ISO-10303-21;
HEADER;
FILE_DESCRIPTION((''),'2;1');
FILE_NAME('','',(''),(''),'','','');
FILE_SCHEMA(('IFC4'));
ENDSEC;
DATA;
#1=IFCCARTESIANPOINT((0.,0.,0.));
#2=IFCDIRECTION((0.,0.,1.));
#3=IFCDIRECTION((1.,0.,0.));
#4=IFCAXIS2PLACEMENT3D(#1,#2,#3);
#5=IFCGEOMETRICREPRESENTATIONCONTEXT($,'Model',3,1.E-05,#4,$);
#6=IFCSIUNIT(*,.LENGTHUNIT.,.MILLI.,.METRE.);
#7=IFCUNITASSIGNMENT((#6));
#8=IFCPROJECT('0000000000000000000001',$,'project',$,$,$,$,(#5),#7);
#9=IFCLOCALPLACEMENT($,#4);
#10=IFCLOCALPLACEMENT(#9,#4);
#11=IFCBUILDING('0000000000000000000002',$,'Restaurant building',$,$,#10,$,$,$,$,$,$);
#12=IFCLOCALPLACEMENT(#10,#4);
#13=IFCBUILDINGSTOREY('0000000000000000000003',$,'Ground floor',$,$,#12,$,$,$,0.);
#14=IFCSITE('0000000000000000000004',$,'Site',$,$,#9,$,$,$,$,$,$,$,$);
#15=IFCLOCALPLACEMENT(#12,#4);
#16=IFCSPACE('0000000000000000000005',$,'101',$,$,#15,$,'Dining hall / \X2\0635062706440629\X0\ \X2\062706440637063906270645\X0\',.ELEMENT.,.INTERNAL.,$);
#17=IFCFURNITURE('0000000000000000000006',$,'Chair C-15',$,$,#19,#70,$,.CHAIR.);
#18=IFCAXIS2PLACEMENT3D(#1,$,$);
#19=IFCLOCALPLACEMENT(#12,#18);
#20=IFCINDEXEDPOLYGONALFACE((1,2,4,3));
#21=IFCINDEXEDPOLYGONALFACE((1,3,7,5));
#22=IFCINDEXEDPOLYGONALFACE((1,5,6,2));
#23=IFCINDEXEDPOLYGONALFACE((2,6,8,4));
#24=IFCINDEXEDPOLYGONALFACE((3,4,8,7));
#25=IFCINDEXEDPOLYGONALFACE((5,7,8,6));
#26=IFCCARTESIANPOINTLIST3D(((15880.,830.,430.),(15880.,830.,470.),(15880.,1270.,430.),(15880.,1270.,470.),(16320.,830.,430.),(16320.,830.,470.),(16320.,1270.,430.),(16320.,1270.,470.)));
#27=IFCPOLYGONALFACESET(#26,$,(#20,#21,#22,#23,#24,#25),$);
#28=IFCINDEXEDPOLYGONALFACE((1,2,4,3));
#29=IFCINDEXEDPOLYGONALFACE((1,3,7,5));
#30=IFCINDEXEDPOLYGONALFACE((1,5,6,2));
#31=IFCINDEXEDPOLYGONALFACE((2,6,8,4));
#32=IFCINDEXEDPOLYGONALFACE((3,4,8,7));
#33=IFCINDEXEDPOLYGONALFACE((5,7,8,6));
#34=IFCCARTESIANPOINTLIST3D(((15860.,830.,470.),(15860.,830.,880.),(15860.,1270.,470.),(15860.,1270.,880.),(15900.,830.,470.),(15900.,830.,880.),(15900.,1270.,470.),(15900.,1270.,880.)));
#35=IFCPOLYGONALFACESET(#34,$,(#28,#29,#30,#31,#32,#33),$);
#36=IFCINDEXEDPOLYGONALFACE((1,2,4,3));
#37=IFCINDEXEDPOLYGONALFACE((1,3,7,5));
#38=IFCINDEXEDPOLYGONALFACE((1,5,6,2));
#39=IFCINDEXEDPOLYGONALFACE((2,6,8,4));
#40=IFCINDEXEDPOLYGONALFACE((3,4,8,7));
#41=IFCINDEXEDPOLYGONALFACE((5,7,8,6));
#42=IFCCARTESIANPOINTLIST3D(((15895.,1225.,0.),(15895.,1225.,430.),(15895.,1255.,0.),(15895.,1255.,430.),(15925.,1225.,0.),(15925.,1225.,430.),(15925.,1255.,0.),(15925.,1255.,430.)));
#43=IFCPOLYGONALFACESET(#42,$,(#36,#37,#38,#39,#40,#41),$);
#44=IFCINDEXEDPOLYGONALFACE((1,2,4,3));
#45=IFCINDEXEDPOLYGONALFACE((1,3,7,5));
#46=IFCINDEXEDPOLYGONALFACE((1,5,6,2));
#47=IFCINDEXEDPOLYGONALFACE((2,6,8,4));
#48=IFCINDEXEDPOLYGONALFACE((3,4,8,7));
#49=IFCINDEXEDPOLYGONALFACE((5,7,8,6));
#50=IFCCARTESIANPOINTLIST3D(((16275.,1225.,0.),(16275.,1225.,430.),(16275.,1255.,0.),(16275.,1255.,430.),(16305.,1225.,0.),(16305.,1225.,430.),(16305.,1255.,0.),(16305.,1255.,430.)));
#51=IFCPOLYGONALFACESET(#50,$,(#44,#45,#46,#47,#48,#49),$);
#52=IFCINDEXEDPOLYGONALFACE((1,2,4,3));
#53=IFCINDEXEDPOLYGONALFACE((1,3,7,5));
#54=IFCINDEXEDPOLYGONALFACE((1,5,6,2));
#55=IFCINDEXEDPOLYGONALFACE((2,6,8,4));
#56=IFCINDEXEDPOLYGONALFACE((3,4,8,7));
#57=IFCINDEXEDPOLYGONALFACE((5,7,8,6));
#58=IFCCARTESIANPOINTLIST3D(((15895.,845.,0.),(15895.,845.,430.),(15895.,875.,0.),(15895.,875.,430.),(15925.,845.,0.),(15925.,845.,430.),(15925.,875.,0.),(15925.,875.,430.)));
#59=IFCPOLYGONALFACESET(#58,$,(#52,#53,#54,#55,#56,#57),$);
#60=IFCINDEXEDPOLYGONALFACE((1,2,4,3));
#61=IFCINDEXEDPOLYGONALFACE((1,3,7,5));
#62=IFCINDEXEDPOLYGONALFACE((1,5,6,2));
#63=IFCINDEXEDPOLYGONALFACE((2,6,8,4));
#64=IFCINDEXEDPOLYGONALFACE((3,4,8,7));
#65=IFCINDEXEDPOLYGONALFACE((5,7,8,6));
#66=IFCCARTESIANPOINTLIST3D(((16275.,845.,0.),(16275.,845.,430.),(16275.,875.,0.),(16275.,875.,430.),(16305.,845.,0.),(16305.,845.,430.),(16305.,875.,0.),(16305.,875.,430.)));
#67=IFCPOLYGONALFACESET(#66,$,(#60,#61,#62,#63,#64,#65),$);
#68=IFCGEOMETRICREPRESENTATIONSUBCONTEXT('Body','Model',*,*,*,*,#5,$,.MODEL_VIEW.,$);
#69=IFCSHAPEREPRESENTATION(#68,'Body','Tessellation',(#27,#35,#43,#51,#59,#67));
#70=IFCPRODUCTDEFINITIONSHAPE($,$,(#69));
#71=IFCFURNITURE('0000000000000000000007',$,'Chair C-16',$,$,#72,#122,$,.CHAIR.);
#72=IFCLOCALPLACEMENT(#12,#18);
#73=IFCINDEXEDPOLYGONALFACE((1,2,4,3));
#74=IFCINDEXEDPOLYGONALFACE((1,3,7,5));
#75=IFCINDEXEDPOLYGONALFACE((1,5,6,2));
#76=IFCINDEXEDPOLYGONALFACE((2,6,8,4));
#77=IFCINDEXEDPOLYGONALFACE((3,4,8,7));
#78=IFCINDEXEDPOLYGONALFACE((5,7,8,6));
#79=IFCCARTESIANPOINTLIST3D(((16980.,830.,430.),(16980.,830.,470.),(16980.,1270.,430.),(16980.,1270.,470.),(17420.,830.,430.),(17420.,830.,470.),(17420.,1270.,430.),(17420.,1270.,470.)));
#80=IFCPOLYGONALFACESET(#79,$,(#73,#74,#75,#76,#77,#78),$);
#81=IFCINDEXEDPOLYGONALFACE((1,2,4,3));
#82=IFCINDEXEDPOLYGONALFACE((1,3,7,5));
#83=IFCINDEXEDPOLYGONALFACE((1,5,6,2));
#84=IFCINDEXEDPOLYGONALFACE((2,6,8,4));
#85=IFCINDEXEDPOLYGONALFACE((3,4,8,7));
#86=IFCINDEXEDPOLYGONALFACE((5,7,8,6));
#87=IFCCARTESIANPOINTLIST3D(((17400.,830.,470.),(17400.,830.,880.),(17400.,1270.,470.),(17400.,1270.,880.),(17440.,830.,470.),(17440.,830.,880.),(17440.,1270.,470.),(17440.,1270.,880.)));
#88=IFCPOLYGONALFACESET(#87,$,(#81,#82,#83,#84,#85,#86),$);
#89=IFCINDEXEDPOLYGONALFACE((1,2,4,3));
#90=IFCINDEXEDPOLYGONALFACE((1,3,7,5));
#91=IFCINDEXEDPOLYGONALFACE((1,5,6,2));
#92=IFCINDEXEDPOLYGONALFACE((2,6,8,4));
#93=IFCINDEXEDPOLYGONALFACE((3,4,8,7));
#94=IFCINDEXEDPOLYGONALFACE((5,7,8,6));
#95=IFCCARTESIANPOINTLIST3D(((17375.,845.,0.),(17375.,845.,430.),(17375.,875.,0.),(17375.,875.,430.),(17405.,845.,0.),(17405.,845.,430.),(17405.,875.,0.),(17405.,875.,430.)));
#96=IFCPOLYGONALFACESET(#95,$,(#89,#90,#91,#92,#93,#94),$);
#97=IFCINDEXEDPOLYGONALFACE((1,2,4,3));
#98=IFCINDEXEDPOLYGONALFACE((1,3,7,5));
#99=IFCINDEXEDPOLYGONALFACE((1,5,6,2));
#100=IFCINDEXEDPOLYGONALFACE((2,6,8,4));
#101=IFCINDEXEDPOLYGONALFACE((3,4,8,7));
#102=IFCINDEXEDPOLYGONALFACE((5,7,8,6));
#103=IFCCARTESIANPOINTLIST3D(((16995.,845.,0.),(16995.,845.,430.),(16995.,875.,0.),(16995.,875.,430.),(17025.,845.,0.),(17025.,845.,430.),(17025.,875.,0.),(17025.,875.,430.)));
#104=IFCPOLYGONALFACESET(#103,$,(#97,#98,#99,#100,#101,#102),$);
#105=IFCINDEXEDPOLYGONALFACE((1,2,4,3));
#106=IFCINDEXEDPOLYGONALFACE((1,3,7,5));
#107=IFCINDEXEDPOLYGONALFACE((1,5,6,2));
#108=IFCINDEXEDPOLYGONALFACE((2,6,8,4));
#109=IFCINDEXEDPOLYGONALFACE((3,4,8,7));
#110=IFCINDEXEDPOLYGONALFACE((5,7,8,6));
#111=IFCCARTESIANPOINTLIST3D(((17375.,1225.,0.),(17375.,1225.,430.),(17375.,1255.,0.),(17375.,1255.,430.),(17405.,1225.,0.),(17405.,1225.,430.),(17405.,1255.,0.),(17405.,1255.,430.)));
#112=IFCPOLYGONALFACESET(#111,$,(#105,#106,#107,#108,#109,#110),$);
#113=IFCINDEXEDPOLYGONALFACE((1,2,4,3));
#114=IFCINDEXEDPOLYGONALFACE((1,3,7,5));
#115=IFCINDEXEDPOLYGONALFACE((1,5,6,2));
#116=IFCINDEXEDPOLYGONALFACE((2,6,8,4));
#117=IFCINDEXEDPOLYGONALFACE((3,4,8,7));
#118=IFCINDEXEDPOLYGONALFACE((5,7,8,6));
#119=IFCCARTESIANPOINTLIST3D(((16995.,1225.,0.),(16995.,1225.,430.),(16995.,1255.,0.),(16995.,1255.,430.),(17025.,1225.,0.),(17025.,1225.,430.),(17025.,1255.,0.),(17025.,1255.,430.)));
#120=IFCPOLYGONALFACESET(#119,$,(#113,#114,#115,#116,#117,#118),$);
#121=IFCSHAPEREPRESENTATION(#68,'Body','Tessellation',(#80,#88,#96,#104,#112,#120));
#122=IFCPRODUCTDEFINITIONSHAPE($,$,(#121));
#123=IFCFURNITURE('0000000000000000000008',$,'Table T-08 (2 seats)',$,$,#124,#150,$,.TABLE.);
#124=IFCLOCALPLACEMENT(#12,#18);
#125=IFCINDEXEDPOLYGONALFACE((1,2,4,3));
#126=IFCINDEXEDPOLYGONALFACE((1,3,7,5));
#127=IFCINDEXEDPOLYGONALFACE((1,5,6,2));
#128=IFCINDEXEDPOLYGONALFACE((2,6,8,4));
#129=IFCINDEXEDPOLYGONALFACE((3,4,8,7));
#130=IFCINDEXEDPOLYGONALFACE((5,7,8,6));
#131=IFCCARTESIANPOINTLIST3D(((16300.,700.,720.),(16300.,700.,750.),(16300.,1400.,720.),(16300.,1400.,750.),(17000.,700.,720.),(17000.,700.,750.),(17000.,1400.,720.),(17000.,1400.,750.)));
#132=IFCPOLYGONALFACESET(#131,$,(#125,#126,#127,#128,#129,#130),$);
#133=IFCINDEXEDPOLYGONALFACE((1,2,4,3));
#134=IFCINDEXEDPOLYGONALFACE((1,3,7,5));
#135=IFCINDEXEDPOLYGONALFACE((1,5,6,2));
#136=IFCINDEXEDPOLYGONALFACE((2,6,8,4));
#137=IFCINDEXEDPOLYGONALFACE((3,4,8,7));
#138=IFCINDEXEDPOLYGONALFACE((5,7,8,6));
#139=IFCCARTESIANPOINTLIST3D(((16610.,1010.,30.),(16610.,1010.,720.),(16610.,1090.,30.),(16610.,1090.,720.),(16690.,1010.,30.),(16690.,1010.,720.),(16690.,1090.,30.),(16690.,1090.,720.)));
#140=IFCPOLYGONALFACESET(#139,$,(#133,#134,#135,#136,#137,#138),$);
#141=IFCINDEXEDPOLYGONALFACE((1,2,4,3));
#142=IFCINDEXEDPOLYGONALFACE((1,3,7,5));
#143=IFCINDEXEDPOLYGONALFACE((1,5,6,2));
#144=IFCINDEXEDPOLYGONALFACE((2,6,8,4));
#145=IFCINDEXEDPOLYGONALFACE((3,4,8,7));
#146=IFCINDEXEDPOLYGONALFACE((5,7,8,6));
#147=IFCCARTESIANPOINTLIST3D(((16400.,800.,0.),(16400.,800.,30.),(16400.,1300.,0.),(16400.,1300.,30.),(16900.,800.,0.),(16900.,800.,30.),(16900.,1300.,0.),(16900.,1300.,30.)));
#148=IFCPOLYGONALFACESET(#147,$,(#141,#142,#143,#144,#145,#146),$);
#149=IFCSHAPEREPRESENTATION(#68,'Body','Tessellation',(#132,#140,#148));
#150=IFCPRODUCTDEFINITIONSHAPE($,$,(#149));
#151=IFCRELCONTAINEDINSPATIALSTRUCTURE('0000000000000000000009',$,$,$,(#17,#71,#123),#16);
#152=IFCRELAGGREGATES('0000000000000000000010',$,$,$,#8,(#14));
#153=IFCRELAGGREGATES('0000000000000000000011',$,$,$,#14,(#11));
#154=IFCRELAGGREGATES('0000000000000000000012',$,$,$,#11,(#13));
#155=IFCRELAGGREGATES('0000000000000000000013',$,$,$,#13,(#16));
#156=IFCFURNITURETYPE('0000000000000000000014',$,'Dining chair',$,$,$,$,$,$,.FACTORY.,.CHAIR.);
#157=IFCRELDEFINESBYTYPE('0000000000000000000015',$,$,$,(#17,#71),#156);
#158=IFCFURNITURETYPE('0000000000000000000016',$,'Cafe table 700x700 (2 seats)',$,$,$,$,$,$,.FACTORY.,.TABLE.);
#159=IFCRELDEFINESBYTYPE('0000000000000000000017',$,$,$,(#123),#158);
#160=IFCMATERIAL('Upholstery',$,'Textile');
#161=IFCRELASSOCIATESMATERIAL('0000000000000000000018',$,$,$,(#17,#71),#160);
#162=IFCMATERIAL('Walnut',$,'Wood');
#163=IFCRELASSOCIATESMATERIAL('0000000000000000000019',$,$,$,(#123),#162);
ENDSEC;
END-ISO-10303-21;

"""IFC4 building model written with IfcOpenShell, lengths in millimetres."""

from ifc_helpers import new_model, si_unit, frame, origin, origin_with_axes, origin_2d, place, context, subcontext, project, spatial, rectangle, extrude, source, transform, mapped, material, type_object, type_shapes, element, save


model = new_model("IFC4")

# Units and contexts
model_context = context("Model", 3, precision=1e-05, world=origin_with_axes())
body_context = subcontext(model_context, "Body", "Model", "MODEL_VIEW")
ifc_project = project(units=[si_unit("LENGTHUNIT", "METRE", prefix="MILLI")], contexts=[model_context])

# Site, building, storey
site_placement = place(None, origin_with_axes())
site = spatial("IfcSite", under=ifc_project, at=site_placement, Name="Site")
building_placement = place(site_placement, origin_with_axes())
building = spatial("IfcBuilding", under=site, at=building_placement, Name="Restaurant building")
storey_placement = place(building_placement, origin_with_axes())
storey = spatial("IfcBuildingStorey", under=building, at=storey_placement, Name="Ground floor", Elevation=0.0)

# Shared definitions
space_placement = place(storey_placement, origin_with_axes())
space = spatial("IfcSpace", under=storey, at=space_placement, Name="101", LongName="Dining hall / صالة الطعام", CompositionType="ELEMENT", PredefinedType="INTERNAL")

# Furniture
ifc_material_1 = material(Name="Upholstery", Category="Textile")
furniture_type_1 = type_object("IfcFurnitureType", Name="Dining chair", AssemblyPlace="FACTORY", PredefinedType="CHAIR")
shared_shape_1 = source(origin(), body_context, "Body", "SweptSolid", [
    extrude(rectangle(XDim=440.0, YDim=440.0, at=origin_2d()), frame((0.0, 0.0, 430.0)), (0.0, 0.0, 1.0), 40.0),
    extrude(rectangle(XDim=440.0, YDim=40.0, at=origin_2d()), frame((0.0, -220.0, 470.0)), (0.0, 0.0, 1.0), 410.0),
    extrude(rectangle(XDim=30.0, YDim=30.0, at=origin_2d()), frame((-190.0, -190.0, 0.0)), (0.0, 0.0, 1.0), 430.0),
    extrude(rectangle(XDim=30.0, YDim=30.0, at=origin_2d()), frame((-190.0, 190.0, 0.0)), (0.0, 0.0, 1.0), 430.0),
    extrude(rectangle(XDim=30.0, YDim=30.0, at=origin_2d()), frame((190.0, -190.0, 0.0)), (0.0, 0.0, 1.0), 430.0),
    extrude(rectangle(XDim=30.0, YDim=30.0, at=origin_2d()), frame((190.0, 190.0, 0.0)), (0.0, 0.0, 1.0), 430.0),
])
type_shapes(furniture_type_1, [shared_shape_1])
for number, where, z_axis, x_axis, name in (
    (1, (16100.0, 1050.0, 0.0), (0.0, 0.0, 1.0), (0.0, -1.0, 0.0), "Chair C-15"),
    (2, (17200.0, 1050.0, 0.0), (0.0, 0.0, 1.0), (0.0, 1.0, 0.0), "Chair C-16"),
):
    element("IfcFurniture", number, at=place(storey_placement, frame(where, z_axis=z_axis, x_axis=x_axis)), inside=space, type_object=furniture_type_1, material=ifc_material_1, Name=name, PredefinedType="CHAIR", context=body_context, shape_type="MappedRepresentation", body=[
        mapped(shared_shape_1, transform((0.0, 0.0, 0.0))),
    ])
ifc_material_2 = material(Name="Walnut", Category="Wood")
furniture_type_2 = type_object("IfcFurnitureType", Name="Cafe table 700x700 (2 seats)", AssemblyPlace="FACTORY", PredefinedType="TABLE")
shared_shape_2 = source(origin(), body_context, "Body", "SweptSolid", [
    extrude(rectangle(XDim=700.0, YDim=700.0, at=origin_2d()), frame((0.0, 0.0, 720.0)), (0.0, 0.0, 1.0), 30.0),
    extrude(rectangle(XDim=80.0, YDim=80.0, at=origin_2d()), frame((0.0, 0.0, 30.0)), (0.0, 0.0, 1.0), 690.0),
    extrude(rectangle(XDim=500.0, YDim=500.0, at=origin_2d()), origin(), (0.0, 0.0, 1.0), 30.0),
])
type_shapes(furniture_type_2, [shared_shape_2])
furniture_placement = place(storey_placement, frame((16650.0, 1050.0, 0.0)))
element("IfcFurniture", 3, at=furniture_placement, inside=space, type_object=furniture_type_2, material=ifc_material_2, Name="Table T-08 (2 seats)", PredefinedType="TABLE", context=body_context, shape_type="MappedRepresentation", body=[
    mapped(shared_shape_2, transform((0.0, 0.0, 0.0))),
])

save(model, "model.ifc")
